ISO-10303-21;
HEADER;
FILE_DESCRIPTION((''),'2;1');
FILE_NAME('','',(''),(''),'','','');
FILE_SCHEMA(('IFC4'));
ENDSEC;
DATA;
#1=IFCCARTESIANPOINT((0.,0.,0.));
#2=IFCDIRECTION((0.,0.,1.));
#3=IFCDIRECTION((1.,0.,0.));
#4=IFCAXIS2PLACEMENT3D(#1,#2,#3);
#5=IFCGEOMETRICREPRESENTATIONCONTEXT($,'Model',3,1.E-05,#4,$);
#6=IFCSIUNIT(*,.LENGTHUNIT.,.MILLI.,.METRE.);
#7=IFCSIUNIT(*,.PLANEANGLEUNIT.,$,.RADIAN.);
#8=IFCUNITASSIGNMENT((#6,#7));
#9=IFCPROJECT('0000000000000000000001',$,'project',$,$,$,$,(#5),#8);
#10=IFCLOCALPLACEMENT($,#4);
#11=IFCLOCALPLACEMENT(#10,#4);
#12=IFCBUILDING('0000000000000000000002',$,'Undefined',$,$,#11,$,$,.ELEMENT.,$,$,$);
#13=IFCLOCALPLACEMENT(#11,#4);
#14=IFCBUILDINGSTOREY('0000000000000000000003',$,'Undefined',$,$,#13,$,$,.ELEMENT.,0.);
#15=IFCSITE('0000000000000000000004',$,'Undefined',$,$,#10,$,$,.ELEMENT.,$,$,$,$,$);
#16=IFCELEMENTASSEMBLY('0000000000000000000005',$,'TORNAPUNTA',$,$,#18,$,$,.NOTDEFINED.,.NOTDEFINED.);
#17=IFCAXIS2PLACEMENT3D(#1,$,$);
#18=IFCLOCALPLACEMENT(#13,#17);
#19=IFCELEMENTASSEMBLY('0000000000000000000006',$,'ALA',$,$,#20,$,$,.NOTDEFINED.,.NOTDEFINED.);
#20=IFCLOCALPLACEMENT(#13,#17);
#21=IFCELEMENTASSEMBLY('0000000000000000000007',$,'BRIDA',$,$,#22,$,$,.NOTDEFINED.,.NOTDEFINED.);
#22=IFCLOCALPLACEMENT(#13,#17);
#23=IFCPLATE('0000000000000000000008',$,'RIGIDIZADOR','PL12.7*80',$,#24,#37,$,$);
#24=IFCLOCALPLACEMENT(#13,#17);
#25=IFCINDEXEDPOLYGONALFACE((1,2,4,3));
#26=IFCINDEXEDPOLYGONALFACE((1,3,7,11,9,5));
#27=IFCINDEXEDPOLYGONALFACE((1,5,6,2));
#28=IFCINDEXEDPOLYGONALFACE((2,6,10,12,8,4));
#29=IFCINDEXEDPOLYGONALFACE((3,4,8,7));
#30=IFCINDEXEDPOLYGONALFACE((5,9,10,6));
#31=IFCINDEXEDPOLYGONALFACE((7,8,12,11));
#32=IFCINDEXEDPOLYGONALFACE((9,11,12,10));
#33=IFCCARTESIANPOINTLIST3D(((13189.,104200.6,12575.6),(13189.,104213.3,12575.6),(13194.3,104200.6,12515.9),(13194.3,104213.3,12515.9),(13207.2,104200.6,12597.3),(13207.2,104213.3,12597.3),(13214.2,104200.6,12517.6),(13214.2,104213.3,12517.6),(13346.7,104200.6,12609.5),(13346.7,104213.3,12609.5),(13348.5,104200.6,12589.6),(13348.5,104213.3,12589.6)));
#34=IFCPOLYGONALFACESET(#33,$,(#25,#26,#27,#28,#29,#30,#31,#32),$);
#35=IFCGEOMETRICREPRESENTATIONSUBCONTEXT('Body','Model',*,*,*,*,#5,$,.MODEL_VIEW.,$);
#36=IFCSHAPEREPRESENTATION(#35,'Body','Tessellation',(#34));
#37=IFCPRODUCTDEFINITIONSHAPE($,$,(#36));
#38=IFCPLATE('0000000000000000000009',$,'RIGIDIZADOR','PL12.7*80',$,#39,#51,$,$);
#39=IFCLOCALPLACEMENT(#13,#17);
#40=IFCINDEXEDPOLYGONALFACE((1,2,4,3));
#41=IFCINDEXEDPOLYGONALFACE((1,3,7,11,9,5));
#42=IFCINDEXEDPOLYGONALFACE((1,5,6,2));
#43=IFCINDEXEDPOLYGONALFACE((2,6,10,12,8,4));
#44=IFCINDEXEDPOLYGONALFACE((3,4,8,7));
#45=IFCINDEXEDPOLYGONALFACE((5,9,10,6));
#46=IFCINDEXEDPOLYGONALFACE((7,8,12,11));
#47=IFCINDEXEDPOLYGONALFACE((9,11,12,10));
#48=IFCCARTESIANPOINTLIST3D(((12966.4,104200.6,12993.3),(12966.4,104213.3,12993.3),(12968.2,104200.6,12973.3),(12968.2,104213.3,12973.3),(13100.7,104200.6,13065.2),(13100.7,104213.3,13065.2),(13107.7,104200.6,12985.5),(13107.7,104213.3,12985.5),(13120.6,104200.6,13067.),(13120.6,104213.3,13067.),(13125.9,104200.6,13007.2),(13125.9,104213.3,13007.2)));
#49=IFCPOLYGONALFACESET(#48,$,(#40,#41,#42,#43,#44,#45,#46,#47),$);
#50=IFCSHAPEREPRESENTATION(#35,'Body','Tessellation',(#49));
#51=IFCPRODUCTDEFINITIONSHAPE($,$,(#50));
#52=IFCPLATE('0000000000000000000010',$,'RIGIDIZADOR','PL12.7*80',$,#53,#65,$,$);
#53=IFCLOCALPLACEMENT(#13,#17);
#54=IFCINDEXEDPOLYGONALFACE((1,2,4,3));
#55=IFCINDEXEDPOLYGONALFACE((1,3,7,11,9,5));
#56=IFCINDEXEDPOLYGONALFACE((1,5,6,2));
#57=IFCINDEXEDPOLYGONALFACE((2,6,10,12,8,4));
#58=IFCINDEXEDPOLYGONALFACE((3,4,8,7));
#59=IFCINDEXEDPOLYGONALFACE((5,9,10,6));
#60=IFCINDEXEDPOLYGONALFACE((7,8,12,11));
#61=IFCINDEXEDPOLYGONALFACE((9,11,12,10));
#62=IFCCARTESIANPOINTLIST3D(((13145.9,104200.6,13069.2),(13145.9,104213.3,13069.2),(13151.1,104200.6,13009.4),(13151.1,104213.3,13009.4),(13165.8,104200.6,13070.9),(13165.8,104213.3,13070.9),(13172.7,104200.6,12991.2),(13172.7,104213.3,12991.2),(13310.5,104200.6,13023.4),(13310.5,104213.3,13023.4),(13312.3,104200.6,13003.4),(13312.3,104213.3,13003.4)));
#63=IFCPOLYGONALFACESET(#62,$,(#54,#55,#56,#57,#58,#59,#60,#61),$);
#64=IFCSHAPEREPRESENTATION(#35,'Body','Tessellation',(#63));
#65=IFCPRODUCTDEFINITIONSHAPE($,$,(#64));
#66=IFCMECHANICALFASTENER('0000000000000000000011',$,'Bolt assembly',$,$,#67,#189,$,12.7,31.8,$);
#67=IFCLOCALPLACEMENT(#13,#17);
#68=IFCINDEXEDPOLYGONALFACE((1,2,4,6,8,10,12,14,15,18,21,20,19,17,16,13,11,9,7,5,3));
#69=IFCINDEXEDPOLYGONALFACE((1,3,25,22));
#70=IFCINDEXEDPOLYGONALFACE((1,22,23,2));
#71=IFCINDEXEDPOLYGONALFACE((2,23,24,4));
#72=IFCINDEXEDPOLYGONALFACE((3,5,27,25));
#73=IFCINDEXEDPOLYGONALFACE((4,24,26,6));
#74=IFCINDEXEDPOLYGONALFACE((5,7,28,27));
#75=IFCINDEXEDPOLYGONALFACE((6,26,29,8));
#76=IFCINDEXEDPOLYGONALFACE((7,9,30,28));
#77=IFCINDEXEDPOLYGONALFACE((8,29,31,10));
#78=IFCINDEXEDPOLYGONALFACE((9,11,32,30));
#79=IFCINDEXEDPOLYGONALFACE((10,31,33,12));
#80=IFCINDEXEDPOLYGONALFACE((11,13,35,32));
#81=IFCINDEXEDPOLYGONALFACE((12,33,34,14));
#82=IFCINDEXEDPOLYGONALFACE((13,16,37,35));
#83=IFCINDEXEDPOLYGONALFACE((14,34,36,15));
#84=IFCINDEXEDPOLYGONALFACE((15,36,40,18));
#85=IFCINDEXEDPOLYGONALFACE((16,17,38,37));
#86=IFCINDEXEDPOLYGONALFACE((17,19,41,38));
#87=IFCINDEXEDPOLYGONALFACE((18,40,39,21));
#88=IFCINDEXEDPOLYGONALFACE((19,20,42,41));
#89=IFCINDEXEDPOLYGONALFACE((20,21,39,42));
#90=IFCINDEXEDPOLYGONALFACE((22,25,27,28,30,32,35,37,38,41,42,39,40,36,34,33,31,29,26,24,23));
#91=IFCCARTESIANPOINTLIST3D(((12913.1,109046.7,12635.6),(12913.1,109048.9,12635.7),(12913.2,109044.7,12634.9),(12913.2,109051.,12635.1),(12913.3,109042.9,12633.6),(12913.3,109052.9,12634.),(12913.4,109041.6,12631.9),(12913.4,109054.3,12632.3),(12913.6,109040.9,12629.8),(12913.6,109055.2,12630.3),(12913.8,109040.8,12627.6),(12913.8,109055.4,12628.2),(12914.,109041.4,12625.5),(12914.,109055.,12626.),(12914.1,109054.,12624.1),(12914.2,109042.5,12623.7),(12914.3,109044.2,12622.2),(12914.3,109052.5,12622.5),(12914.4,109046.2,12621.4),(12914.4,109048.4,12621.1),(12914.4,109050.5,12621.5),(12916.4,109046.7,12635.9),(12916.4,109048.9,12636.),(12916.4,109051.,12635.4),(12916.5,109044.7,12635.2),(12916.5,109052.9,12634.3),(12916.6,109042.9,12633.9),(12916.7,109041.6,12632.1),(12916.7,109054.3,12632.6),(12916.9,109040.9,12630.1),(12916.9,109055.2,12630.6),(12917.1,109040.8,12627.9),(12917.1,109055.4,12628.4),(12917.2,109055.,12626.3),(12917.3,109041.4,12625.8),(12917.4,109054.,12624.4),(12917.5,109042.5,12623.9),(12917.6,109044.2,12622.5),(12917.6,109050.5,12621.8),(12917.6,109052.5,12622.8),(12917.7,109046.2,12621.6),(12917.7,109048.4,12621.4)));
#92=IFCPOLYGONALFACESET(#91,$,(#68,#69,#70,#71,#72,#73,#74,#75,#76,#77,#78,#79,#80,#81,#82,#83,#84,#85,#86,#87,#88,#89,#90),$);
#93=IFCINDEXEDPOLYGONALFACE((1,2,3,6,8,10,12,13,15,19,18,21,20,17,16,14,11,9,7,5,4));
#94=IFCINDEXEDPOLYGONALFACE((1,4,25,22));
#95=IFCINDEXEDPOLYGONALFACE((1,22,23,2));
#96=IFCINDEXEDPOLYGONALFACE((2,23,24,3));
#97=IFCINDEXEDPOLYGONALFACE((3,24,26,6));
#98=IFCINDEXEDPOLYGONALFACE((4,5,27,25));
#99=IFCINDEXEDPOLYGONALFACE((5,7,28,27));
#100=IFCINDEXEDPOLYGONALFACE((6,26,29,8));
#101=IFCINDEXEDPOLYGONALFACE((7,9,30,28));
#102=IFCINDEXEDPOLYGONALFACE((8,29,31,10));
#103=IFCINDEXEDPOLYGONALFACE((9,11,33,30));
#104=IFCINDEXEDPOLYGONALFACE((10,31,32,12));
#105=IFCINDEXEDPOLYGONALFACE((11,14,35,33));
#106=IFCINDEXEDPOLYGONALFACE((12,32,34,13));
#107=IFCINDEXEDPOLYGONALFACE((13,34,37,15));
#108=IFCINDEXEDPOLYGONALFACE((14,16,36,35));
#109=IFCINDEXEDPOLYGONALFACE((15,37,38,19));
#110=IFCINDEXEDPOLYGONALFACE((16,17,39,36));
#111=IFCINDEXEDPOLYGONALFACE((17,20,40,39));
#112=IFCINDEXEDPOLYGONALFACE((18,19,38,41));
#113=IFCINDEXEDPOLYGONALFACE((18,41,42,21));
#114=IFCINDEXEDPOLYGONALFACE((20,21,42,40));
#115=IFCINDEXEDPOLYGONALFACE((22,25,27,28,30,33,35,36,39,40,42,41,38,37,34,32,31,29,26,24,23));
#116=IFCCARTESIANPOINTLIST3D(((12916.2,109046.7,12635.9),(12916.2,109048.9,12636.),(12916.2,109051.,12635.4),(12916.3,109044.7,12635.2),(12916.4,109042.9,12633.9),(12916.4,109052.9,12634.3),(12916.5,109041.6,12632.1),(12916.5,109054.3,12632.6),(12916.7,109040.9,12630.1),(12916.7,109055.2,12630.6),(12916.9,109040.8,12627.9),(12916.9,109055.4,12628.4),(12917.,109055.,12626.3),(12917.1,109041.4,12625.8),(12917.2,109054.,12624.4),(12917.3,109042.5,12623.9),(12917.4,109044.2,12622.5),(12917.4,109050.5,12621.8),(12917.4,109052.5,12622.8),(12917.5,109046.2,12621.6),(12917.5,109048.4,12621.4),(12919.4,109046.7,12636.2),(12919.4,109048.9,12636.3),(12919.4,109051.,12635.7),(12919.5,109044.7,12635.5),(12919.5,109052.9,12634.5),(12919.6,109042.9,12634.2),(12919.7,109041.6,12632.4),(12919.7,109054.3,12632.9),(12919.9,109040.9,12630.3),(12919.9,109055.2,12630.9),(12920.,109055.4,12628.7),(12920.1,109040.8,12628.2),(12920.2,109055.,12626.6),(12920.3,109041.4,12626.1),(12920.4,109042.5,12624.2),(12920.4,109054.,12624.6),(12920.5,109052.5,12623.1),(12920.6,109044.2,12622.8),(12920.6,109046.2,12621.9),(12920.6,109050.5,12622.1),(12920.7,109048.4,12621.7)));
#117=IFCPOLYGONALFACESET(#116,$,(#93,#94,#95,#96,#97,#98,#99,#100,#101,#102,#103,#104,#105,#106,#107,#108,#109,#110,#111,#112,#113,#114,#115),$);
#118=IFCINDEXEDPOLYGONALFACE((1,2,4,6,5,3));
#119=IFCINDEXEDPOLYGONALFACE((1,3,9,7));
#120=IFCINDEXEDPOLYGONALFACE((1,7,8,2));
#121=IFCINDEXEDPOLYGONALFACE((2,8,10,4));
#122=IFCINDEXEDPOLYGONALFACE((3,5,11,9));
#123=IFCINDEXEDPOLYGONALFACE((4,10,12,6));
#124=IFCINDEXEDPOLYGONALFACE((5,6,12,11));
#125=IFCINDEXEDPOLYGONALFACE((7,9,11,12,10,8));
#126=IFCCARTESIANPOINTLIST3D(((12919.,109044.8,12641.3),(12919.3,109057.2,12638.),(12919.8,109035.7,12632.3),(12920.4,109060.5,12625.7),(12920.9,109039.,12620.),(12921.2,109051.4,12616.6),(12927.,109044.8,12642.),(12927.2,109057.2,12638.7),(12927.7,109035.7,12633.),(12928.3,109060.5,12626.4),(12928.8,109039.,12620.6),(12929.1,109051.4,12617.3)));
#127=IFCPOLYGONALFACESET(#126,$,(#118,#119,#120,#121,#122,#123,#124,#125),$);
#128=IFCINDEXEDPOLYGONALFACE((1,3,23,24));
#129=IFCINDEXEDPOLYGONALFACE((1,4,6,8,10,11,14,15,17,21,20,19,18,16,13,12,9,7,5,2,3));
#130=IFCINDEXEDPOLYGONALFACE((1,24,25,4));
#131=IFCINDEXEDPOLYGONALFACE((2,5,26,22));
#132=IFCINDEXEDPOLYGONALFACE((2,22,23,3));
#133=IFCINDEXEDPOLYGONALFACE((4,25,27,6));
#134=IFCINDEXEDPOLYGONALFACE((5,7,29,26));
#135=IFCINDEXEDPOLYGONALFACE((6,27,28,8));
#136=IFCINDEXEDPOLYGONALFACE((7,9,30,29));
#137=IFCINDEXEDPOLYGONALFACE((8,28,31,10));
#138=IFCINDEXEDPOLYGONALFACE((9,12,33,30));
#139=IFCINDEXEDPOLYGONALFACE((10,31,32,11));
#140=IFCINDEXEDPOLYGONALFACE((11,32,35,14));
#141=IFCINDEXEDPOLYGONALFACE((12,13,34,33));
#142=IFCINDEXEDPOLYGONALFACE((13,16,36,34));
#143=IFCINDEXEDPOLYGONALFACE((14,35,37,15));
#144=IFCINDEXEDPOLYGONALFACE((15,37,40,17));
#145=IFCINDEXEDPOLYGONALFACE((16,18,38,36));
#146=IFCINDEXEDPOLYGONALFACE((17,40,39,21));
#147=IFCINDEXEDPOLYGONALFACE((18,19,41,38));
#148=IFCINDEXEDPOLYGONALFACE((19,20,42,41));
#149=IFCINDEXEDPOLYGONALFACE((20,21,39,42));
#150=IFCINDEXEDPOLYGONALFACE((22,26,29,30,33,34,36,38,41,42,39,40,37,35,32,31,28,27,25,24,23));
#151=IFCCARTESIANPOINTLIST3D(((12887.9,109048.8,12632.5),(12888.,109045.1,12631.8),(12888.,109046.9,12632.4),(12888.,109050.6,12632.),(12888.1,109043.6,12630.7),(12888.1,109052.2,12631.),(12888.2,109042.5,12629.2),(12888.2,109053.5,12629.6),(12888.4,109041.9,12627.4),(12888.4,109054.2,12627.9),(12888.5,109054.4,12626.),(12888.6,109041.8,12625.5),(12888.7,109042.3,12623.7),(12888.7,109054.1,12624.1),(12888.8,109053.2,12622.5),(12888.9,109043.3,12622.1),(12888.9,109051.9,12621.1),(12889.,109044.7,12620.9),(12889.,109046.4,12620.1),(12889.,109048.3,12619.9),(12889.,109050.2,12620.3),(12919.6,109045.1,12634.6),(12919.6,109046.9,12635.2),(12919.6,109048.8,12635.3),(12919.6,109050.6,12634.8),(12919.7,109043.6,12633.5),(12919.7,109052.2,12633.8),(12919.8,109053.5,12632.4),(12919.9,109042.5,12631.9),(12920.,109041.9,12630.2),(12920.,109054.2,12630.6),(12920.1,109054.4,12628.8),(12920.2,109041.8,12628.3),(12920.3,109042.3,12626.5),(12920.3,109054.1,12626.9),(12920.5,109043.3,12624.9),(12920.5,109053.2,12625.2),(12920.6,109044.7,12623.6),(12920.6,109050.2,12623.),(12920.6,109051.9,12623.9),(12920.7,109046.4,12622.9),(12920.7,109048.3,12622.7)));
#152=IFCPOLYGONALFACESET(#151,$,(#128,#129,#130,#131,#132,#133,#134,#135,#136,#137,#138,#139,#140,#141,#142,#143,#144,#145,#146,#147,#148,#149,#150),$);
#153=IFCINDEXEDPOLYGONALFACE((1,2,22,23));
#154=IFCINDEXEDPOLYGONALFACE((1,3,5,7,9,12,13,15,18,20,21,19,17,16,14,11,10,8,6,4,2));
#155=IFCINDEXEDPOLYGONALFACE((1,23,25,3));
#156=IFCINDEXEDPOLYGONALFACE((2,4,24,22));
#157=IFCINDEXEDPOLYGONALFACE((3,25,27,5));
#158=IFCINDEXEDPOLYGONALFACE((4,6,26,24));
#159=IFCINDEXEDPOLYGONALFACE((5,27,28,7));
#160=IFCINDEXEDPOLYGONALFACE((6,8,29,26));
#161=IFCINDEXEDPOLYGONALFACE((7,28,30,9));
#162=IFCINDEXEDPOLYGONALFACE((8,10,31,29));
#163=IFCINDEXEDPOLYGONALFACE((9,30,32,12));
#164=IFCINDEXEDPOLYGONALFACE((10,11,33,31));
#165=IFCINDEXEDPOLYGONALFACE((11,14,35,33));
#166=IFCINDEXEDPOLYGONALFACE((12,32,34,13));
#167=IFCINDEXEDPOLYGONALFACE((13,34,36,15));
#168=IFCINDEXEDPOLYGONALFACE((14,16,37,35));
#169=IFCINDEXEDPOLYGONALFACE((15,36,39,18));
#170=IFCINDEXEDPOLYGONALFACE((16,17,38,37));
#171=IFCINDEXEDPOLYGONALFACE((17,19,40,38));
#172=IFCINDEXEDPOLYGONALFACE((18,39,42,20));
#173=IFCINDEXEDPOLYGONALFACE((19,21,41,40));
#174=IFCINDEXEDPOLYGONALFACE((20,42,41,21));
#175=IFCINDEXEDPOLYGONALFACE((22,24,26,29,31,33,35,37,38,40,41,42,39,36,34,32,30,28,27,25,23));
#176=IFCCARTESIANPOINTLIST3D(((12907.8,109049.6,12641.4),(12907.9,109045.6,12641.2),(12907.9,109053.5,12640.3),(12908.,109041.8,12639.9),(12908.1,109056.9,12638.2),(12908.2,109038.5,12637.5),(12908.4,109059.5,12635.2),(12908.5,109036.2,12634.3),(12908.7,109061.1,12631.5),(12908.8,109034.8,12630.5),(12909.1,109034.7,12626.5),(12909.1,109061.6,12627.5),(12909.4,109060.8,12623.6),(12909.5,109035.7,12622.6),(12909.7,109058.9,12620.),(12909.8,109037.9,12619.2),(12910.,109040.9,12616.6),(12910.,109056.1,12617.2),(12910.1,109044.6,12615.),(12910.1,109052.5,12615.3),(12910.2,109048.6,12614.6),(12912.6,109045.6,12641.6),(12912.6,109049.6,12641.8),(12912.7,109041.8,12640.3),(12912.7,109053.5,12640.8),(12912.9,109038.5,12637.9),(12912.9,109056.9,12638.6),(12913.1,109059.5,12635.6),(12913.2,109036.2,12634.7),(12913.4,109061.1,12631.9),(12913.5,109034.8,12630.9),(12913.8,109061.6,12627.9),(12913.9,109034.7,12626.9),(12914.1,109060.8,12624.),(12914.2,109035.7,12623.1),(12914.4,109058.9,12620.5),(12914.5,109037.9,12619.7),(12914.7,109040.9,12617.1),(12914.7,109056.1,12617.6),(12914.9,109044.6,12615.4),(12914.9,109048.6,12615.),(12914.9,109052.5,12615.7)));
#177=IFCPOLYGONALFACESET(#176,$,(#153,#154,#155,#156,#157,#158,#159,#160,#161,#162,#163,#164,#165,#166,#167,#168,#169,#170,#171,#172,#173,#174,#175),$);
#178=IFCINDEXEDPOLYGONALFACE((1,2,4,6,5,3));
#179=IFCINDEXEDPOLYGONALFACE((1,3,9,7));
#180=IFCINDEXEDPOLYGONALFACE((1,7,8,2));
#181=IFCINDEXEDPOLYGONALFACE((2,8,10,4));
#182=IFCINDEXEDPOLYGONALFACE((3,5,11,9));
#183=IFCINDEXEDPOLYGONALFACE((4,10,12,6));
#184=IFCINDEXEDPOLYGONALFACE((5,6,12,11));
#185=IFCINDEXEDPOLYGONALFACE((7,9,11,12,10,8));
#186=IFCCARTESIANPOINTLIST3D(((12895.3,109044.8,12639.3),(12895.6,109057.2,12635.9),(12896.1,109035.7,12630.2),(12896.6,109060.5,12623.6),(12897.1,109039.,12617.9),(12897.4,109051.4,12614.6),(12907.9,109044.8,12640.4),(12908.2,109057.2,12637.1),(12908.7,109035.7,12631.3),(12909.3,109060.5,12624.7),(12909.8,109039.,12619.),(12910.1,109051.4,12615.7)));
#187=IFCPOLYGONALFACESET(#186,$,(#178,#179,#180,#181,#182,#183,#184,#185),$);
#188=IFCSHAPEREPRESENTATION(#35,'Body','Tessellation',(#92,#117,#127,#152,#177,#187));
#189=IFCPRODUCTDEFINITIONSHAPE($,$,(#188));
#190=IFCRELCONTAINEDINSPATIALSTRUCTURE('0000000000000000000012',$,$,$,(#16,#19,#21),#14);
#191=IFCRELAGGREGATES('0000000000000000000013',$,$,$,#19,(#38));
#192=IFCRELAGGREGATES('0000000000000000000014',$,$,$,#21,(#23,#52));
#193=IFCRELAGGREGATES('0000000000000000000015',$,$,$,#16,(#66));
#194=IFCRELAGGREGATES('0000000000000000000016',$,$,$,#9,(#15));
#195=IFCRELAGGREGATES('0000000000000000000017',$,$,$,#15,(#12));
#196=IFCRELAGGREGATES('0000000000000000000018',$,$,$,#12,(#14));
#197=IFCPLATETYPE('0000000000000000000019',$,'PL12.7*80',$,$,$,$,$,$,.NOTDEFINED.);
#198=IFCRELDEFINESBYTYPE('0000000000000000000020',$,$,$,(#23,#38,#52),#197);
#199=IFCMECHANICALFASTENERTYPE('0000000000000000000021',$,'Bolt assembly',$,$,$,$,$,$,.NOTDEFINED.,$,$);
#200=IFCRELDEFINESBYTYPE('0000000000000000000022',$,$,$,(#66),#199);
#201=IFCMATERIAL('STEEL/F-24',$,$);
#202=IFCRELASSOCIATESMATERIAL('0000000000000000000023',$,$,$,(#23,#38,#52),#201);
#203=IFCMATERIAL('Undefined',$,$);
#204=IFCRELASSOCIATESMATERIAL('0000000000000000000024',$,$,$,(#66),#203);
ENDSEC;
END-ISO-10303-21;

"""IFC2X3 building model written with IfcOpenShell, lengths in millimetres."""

from ifc_helpers import new_model, si_unit, frame, origin_with_axes, origin_2d_with_axis, place, context, subcontext, project, spatial, polyline, circle, outline, extrude, source, transform, mapped, material, type_object, element, aggregate, save


model = new_model("IFC2X3")

# Units and contexts
model_context = context("Model", 3, precision=1e-05, world=origin_with_axes())
body_context = subcontext(model_context, "Body", "Model", "MODEL_VIEW")
ifc_project = project(units=[si_unit("LENGTHUNIT", "METRE", prefix="MILLI"), si_unit("PLANEANGLEUNIT", "RADIAN")], contexts=[model_context])

# Site, building, storey
site_placement = place(None, origin_with_axes())
site = spatial("IfcSite", under=ifc_project, at=site_placement, Name="Undefined", CompositionType="ELEMENT")
building_placement = place(site_placement, origin_with_axes())
building = spatial("IfcBuilding", under=site, at=building_placement, Name="Undefined", CompositionType="ELEMENT")
storey_placement = place(building_placement, origin_with_axes())
storey = spatial("IfcBuildingStorey", under=building, at=storey_placement, Name="Undefined", CompositionType="ELEMENT", Elevation=0.0)

# Element assemblies
assembly_1_placement = place(storey_placement, origin_with_axes())
assembly_1 = element("IfcElementAssembly", 1, at=assembly_1_placement, inside=storey, Name="TORNAPUNTA", AssemblyPlace="NOTDEFINED", PredefinedType="NOTDEFINED")
ifc_material_1 = material(Name="STEEL/F-24")
assembly_2_placement = place(storey_placement, origin_with_axes())
assembly_2 = element("IfcElementAssembly", 2, at=assembly_2_placement, inside=storey, Name="ALA", AssemblyPlace="NOTDEFINED", PredefinedType="NOTDEFINED")
assembly_3_placement = place(storey_placement, origin_with_axes())
assembly_3 = element("IfcElementAssembly", 3, at=assembly_3_placement, inside=storey, Name="BRIDA", AssemblyPlace="NOTDEFINED", PredefinedType="NOTDEFINED")

# Plates
plate_type_1 = type_object("IfcPlateType", Name="PL12.7*80", PredefinedType="NOTDEFINED")
plate_1_placement = place(assembly_3_placement, frame((13187.3, 104207.0, 12595.6), z_axis=(0.0, -1.0, 0.0), x_axis=(0.087972, 0.0, -0.996123)))
plate_1 = element("IfcPlate", 4, at=plate_1_placement, type_object=plate_type_1, material=ifc_material_1, Name="RIGIDIZADOR", Description="PL12.7*80", context=body_context, shape_type="SweptSolid", body=[
    extrude(outline(polyline([(0.0, 20.0), (20.0, 0.0), (80.0, 0.0), (80.0, 20.0), (20.1, 160.0), (0.1, 160.1), (0.0, 20.0)])), frame((0.0, 0.0, -6.3), z_axis=(0.0, 0.0, 1.0), x_axis=(1.0, 0.0, 0.0)), (0.0, 0.0, 1.0), 12.7),
])
plate_2_placement = place(assembly_2_placement, frame((13127.6, 104207.0, 12987.3), z_axis=(0.0, -1.0, 0.0), x_axis=(-0.087972, 0.0, 0.996123)))
plate_2 = element("IfcPlate", 5, at=plate_2_placement, type_object=plate_type_1, material=ifc_material_1, Name="RIGIDIZADOR", Description="PL12.7*80", context=body_context, shape_type="SweptSolid", body=[
    extrude(outline(polyline([(0.0, 20.0), (20.0, 0.0), (80.0, 0.0), (80.0, 20.0), (20.1, 160.0), (0.1, 160.1), (0.0, 20.0)])), frame((0.0, 0.0, -6.3), z_axis=(0.0, 0.0, 1.0), x_axis=(1.0, 0.0, 0.0)), (0.0, 0.0, 1.0), 12.7),
])
aggregate(assembly_2, [plate_2])
plate_3_placement = place(assembly_3_placement, frame((13152.8, 104207.0, 12989.5), z_axis=(0.0, 1.0, 0.0), x_axis=(-0.086338, 0.0, 0.996266)))
plate_3 = element("IfcPlate", 6, at=plate_3_placement, type_object=plate_type_1, material=ifc_material_1, Name="RIGIDIZADOR", Description="PL12.7*80", context=body_context, shape_type="SweptSolid", body=[
    extrude(outline(polyline([(0.0, 20.0), (20.0, 0.0), (80.0, 0.0), (80.0, 20.0), (20.1, 160.0), (0.1, 160.1), (0.0, 20.0)])), frame((0.0, 0.0, -6.3), z_axis=(0.0, 0.0, 1.0), x_axis=(1.0, 0.0, 0.0)), (0.0, 0.0, 1.0), 12.7),
])
aggregate(assembly_3, [plate_1, plate_3])

# Mechanical fastener
ifc_material_2 = material(Name="Undefined")
mechanical_fastener_type = type_object("IfcMechanicalFastenerType", Name="Bolt assembly")
shared_shape_1 = source(origin_with_axes(), body_context, "Body", "SweptSolid", [
    extrude(circle(Radius=7.3, at=origin_2d_with_axis()), frame((0.0, -0.1, 0.0), z_axis=(0.0, 1.0, 0.0), x_axis=(1.0, 0.0, 0.0)), (0.0, 0.0, 1.0), 3.3),
    extrude(circle(Radius=7.3, at=origin_2d_with_axis()), frame((0.0, -3.1, 0.0), z_axis=(0.0, 1.0, 0.0), x_axis=(1.0, 0.0, 0.0)), (0.0, 0.0, 1.0), 3.2),
    extrude(outline(polyline([(11.1, -6.4), (11.1, 6.4), (0.0, 12.8), (-11.1, 6.4), (-11.1, -6.4), (0.0, -12.8), (11.1, -6.4)])), frame((0.0, -11.1, 0.0), z_axis=(0.0, 1.0, 0.0), x_axis=(1.0, 0.0, 0.0)), (0.0, 0.0, 1.0), 7.9),
    extrude(circle(Radius=6.3, at=origin_2d_with_axis()), frame((0.0, -3.2, 0.0), z_axis=(0.0, 1.0, 0.0), x_axis=(1.0, 0.0, 0.0)), (0.0, 0.0, 1.0), 31.8),
    extrude(circle(Radius=13.5, at=origin_2d_with_axis()), frame((0.0, 3.2, 0.0), z_axis=(0.0, 1.0, 0.0), x_axis=(1.0, 0.0, 0.0)), (0.0, 0.0, 1.0), 4.8),
    extrude(outline(polyline([(11.1, -6.4), (11.1, 6.4), (0.0, 12.8), (-11.1, 6.4), (-11.1, -6.4), (0.0, -12.8), (11.1, -6.4)])), frame((0.0, 8.0, 0.0), z_axis=(0.0, 1.0, 0.0), x_axis=(1.0, 0.0, 0.0)), (0.0, 0.0, 1.0), 12.7),
])
mechanical_fastener_1_placement = place(assembly_1_placement, frame((12916.9, 109048.1, 12628.7), z_axis=(0.061628, -0.707107, -0.704416), x_axis=(-0.061628, -0.707107, 0.704416)))
mechanical_fastener_1 = element("IfcMechanicalFastener", 7, at=mechanical_fastener_1_placement, type_object=mechanical_fastener_type, material=ifc_material_2, Name="Bolt assembly", NominalDiameter=12.7, NominalLength=31.8, context=body_context, shape_type="MappedRepresentation", body=[
    mapped(shared_shape_1, transform((0.0, 0.0, 0.0))),
])
aggregate(assembly_1, [mechanical_fastener_1])

save(model, "model.ifc")
